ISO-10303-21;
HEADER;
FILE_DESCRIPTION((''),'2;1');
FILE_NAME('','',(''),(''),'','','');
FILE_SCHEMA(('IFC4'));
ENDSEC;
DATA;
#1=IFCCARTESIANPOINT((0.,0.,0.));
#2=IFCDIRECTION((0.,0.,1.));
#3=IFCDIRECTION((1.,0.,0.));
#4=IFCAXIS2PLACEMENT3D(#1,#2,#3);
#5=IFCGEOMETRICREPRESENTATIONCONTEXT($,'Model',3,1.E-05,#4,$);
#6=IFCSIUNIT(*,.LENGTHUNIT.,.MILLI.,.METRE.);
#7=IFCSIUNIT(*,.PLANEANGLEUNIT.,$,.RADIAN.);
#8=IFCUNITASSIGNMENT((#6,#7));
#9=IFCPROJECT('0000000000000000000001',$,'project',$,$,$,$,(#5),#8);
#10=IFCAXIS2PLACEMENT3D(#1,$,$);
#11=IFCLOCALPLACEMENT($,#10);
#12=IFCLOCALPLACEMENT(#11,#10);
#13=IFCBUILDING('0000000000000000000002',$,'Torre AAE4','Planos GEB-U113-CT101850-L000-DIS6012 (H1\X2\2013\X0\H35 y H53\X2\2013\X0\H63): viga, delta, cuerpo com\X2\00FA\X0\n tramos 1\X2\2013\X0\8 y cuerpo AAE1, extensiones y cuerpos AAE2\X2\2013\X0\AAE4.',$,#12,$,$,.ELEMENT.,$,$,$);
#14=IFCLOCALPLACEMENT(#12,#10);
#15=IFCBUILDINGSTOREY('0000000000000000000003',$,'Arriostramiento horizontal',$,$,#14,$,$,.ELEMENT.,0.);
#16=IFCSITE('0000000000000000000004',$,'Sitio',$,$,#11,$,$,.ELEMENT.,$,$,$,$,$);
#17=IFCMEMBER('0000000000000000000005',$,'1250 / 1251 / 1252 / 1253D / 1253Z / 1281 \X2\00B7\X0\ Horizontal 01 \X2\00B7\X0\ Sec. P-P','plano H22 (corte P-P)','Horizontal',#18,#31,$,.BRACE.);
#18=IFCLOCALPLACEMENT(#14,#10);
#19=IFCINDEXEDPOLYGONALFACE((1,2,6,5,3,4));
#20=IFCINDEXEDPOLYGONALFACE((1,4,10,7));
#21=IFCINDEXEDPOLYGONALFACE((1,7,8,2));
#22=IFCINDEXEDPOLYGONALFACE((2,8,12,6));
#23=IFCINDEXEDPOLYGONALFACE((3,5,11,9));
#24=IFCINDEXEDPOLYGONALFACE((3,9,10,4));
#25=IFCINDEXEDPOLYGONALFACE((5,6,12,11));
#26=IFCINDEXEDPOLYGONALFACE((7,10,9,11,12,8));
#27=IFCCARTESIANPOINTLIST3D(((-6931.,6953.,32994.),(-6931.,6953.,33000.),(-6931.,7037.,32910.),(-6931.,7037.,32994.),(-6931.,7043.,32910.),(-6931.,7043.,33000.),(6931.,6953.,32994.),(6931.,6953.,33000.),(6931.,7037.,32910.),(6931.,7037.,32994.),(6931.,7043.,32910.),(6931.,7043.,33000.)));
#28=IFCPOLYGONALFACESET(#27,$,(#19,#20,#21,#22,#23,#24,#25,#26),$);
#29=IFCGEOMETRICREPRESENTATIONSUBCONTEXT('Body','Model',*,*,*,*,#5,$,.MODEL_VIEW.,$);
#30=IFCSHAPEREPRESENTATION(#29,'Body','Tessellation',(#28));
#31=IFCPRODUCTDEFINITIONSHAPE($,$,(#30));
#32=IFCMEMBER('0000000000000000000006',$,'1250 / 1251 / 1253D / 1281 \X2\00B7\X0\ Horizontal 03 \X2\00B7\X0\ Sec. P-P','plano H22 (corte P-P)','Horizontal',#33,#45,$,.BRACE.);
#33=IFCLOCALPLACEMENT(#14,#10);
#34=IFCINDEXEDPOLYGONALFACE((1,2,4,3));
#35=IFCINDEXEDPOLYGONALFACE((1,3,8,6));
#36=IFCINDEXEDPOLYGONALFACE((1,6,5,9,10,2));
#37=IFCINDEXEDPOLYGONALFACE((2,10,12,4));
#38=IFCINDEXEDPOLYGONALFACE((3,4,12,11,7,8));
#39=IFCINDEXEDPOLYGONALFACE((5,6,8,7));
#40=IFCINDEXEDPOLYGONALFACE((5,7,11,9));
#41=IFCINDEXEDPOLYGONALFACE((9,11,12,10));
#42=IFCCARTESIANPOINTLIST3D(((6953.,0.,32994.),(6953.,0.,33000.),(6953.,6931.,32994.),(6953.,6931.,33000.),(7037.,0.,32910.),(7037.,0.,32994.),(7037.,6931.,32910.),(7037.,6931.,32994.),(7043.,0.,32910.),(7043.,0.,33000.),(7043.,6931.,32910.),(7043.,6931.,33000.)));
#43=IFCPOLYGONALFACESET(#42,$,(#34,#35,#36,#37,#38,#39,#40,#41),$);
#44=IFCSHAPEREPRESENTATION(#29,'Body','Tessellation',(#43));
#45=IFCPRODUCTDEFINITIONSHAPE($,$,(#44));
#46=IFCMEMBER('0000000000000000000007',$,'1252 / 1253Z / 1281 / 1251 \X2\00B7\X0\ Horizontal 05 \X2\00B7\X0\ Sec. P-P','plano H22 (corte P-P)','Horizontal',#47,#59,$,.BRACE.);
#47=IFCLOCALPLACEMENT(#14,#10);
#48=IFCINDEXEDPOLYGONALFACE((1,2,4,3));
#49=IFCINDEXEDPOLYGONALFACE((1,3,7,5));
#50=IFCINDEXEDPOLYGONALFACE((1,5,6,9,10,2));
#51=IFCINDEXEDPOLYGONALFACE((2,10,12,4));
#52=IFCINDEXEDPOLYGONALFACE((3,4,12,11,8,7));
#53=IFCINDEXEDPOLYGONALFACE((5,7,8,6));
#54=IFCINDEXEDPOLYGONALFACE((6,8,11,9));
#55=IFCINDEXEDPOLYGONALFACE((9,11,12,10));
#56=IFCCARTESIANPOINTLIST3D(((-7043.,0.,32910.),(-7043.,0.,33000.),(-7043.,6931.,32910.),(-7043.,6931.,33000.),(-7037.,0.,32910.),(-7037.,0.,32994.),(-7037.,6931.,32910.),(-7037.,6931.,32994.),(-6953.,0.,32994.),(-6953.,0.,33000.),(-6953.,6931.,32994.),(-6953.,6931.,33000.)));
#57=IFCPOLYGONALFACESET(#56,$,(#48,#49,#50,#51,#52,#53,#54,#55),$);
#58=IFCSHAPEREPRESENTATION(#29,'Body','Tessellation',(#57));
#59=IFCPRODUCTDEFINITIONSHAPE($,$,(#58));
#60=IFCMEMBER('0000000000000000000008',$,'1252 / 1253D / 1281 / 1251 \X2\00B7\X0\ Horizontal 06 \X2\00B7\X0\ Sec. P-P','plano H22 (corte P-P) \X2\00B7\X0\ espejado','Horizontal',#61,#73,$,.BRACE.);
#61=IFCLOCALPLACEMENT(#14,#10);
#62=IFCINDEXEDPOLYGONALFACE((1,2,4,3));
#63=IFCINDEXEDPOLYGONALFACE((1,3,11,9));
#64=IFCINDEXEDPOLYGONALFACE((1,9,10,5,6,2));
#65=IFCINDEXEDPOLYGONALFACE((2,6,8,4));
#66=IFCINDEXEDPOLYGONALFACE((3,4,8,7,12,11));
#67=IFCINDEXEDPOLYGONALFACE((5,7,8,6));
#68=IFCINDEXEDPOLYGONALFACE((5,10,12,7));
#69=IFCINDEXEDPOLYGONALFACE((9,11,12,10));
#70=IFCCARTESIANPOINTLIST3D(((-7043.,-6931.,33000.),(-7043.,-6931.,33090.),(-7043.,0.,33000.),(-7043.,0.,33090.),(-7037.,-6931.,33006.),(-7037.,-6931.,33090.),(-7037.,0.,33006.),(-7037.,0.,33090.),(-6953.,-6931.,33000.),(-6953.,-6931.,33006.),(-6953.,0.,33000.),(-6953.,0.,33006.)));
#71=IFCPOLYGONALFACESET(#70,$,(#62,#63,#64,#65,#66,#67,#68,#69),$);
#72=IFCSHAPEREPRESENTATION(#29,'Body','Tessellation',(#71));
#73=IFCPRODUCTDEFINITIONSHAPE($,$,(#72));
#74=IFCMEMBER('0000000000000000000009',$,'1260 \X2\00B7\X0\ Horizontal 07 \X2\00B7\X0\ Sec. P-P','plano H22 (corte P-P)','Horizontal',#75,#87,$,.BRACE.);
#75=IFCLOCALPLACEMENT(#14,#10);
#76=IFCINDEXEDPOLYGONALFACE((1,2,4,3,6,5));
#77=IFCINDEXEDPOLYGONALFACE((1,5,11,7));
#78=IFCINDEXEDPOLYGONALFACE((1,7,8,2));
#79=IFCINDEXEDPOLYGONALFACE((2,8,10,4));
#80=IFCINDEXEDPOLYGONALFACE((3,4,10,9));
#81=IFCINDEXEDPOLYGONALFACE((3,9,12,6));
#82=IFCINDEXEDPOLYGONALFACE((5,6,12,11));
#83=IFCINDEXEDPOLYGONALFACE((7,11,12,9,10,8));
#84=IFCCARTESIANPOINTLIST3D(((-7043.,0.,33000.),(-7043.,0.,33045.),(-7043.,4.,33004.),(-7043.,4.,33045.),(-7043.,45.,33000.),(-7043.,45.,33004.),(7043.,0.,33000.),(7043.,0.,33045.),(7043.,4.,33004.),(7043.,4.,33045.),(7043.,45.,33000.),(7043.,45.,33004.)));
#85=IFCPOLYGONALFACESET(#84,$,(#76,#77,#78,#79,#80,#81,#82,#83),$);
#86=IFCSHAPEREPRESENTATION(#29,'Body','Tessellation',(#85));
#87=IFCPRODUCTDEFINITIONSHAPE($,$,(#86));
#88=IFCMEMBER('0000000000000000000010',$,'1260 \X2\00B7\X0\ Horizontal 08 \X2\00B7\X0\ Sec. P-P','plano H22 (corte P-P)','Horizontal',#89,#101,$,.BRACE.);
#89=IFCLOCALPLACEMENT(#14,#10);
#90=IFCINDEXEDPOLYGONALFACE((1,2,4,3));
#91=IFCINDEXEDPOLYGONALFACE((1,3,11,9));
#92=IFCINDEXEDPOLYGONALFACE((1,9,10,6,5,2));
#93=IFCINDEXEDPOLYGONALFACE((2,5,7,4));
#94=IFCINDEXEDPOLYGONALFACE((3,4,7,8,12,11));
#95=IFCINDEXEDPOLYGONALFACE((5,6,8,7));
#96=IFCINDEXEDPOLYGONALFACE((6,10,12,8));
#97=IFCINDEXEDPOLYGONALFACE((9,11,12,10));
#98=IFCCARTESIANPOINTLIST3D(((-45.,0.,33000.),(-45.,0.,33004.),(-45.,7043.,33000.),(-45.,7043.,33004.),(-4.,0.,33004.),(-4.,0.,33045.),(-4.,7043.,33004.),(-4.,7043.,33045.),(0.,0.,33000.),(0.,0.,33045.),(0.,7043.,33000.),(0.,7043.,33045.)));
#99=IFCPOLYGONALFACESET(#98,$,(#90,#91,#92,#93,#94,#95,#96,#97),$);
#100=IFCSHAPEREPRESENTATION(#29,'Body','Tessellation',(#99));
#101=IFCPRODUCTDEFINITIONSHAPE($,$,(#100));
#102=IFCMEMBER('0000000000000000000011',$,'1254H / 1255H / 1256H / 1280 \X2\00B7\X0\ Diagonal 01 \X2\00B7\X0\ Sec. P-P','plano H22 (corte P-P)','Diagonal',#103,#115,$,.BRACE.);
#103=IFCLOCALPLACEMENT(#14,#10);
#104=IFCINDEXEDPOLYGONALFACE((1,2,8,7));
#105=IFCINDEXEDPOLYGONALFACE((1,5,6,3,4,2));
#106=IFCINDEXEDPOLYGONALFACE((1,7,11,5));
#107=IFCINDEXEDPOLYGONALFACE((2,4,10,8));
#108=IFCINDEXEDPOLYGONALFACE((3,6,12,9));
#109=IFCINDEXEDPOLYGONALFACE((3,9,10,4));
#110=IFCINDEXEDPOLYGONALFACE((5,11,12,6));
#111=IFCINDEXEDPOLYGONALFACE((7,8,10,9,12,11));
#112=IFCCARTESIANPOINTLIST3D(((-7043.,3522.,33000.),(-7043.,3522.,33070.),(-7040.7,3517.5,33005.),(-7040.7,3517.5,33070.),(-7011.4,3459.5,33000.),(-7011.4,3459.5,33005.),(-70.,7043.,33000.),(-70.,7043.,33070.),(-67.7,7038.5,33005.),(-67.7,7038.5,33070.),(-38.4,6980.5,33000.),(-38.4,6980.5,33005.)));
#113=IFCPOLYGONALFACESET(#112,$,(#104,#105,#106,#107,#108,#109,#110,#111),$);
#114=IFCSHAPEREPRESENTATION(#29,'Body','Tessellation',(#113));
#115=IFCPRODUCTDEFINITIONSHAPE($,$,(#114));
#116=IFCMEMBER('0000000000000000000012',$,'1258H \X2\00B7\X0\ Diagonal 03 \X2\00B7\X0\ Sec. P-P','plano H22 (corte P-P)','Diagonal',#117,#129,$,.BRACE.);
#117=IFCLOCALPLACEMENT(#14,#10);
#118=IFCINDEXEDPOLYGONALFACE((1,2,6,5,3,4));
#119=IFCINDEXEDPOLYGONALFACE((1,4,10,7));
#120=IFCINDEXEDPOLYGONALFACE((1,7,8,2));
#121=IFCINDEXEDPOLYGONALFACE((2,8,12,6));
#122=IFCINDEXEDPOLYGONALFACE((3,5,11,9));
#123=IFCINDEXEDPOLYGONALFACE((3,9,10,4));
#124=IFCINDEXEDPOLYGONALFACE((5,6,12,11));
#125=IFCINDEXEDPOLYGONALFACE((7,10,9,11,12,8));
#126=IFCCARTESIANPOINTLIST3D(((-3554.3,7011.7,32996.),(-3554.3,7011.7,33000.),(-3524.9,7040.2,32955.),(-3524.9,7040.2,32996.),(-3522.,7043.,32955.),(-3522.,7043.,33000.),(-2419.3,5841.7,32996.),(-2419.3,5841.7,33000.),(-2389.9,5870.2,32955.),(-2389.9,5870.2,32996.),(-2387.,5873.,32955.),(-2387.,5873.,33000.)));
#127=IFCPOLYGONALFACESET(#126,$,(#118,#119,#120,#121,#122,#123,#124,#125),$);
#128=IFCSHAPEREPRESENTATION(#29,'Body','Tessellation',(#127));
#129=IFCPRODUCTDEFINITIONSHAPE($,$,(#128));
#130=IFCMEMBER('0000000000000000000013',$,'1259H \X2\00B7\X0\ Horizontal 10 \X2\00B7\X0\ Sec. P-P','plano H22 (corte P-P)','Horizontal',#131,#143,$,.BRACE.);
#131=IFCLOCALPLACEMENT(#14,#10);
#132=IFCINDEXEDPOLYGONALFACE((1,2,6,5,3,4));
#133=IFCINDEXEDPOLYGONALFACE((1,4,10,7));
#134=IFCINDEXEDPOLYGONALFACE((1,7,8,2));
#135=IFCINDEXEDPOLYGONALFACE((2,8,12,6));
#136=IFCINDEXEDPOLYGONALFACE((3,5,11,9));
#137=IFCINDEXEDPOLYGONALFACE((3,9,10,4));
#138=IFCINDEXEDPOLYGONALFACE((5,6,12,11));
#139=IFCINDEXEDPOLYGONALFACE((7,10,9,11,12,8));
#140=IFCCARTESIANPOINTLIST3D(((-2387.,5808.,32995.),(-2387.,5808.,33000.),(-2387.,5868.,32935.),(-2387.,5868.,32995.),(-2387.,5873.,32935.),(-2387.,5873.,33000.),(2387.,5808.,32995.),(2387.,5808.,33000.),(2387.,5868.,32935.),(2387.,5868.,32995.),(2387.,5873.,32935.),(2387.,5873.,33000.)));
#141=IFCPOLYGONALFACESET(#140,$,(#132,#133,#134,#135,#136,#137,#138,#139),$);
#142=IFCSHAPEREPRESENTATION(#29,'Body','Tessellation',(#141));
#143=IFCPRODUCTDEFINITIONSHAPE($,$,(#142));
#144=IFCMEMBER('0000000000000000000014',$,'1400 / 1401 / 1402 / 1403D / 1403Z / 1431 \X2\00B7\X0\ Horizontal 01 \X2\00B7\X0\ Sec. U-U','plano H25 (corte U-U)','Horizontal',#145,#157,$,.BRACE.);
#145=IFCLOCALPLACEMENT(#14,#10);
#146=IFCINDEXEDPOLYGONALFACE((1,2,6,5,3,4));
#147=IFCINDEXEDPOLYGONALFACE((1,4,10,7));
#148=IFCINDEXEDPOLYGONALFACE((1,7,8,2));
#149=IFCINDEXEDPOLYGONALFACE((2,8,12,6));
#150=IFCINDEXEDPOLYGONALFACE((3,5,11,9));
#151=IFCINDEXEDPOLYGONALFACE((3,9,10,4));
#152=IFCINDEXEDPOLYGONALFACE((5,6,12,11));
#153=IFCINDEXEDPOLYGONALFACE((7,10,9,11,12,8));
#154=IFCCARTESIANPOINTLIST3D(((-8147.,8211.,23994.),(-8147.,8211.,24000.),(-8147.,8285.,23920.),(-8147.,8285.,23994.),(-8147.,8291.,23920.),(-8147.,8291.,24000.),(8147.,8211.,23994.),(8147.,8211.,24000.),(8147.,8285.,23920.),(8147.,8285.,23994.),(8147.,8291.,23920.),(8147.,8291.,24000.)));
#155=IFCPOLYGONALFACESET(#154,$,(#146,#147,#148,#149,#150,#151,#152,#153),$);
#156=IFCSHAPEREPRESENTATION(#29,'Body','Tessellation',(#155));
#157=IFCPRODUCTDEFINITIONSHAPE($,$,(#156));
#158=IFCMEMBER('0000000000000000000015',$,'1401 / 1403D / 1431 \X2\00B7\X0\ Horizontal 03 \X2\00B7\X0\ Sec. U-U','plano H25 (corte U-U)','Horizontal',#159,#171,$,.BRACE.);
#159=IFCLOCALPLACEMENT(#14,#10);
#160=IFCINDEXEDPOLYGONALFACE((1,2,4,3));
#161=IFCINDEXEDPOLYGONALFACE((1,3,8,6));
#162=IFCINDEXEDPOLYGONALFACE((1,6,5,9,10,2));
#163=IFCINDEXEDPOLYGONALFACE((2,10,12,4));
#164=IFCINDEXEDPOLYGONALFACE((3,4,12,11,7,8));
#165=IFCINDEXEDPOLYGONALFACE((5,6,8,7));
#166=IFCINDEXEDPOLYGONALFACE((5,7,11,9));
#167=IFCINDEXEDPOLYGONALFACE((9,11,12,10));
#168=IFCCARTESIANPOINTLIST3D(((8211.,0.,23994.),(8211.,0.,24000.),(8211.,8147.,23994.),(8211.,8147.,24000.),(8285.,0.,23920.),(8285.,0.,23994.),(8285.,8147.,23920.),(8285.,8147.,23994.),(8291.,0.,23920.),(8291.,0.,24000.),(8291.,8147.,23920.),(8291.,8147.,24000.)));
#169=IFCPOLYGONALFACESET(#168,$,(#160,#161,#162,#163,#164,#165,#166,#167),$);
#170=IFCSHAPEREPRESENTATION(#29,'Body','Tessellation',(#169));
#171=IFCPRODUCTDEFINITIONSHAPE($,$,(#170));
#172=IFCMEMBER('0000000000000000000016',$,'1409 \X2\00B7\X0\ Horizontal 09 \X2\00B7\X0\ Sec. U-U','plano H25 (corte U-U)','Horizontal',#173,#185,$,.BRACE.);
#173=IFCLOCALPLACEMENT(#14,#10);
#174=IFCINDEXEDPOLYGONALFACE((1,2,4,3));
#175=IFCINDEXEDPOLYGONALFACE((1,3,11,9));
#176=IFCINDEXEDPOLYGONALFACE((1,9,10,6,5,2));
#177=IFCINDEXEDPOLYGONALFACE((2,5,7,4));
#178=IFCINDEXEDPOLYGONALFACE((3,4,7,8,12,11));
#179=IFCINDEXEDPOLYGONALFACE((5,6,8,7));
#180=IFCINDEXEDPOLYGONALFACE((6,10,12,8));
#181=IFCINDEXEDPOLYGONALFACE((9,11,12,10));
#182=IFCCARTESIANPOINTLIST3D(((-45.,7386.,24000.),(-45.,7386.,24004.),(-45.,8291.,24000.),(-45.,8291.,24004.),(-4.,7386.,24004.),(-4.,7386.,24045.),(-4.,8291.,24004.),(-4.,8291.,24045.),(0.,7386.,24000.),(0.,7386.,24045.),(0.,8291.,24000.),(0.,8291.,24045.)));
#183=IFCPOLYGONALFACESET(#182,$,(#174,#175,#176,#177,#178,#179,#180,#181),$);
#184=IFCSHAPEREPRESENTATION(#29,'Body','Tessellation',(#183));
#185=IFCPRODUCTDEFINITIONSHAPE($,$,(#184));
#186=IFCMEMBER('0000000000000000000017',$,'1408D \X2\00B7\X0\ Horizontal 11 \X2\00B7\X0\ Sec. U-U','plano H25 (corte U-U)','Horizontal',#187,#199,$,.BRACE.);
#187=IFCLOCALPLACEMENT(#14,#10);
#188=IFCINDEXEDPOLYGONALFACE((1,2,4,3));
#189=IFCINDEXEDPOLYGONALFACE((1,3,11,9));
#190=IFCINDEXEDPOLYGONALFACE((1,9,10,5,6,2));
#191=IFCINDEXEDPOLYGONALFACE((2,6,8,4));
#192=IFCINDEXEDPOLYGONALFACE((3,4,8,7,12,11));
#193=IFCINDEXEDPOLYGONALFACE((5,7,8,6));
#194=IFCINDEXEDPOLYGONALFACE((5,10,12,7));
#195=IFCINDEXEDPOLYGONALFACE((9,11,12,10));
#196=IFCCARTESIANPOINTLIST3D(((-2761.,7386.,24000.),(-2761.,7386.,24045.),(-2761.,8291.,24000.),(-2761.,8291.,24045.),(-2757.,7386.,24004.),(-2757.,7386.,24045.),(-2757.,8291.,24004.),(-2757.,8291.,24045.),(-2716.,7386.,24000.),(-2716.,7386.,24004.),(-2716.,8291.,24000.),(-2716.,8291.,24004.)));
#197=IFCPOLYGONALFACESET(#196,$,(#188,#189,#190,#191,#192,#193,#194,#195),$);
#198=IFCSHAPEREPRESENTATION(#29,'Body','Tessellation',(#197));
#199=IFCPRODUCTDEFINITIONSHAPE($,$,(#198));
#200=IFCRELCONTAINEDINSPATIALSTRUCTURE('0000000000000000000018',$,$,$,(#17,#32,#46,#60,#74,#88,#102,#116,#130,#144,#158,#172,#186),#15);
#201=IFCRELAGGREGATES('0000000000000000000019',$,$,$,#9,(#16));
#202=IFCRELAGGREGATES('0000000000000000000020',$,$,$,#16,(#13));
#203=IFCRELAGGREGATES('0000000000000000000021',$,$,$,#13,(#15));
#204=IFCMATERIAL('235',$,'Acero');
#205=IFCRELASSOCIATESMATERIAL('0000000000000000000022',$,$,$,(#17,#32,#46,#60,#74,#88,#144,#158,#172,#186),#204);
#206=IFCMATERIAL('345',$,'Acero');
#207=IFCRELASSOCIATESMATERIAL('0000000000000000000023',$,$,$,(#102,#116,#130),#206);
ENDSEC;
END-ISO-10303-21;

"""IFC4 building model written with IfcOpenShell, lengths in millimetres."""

from ifc_helpers import new_model, si_unit, frame, frame_2d, origin, origin_with_axes, place, context, subcontext, project, spatial, l_section, extrude, material, element, save


model = new_model("IFC4")

# Units and contexts
model_context = context("Model", 3, precision=1e-05, world=origin_with_axes())
body_context = subcontext(model_context, "Body", "Model", "MODEL_VIEW")
ifc_project = project(units=[si_unit("LENGTHUNIT", "METRE", prefix="MILLI"), si_unit("PLANEANGLEUNIT", "RADIAN")], contexts=[model_context])

# Site, building, storey
site_placement = place(None, origin())
site = spatial("IfcSite", under=ifc_project, at=site_placement, Name="Sitio", CompositionType="ELEMENT")
building_placement = place(site_placement, origin())
building = spatial("IfcBuilding", under=site, at=building_placement, Name="Torre AAE4", Description="Planos GEB-U113-CT101850-L000-DIS6012 (H1–H35 y H53–H63): viga, delta, cuerpo común tramos 1–8 y cuerpo AAE1, extensiones y cuerpos AAE2–AAE4.", CompositionType="ELEMENT")
storey_placement = place(building_placement, origin())
storey = spatial("IfcBuildingStorey", under=building, at=storey_placement, Name="Arriostramiento horizontal", CompositionType="ELEMENT", Elevation=0.0)

# Members
ifc_material_1 = material(Name="235", Category="Acero")
member_1_placement = place(storey_placement, frame((-6931.0, 7043.0, 33000.0), z_axis=(1.0, 0.0, 0.0), x_axis=(0.0, -1.0, 0.0)))
element("IfcMember", 1, at=member_1_placement, inside=storey, material=ifc_material_1, Name="1250 / 1251 / 1252 / 1253D / 1253Z / 1281 · Horizontal 01 · Sec. P-P", Description="plano H22 (corte P-P)", ObjectType="Horizontal", PredefinedType="BRACE", context=body_context, shape_type="SweptSolid", body=[
    extrude(l_section(Depth=90.0, Width=90.0, Thickness=6.0, at=frame_2d((45.0, 45.0))), None, (0.0, 0.0, 1.0), 13862.0),
])
for number, where, z_axis, x_axis, name, description in (
    (2, (7043.0, 6931.0, 33000.0), (0.0, -1.0, 0.0), (-1.0, 0.0, 0.0), "1250 / 1251 / 1253D / 1281 · Horizontal 03 · Sec. P-P", "plano H22 (corte P-P)"),
    (3, (-7043.0, 0.0, 33000.0), (0.0, 1.0, 0.0), (1.0, 0.0, 0.0), "1252 / 1253Z / 1281 / 1251 · Horizontal 05 · Sec. P-P", "plano H22 (corte P-P)"),
    (4, (-7043.0, 0.0, 33000.0), (0.0, -1.0, 0.0), (1.0, 0.0, 0.0), "1252 / 1253D / 1281 / 1251 · Horizontal 06 · Sec. P-P", "plano H22 (corte P-P) · espejado"),
):
    element("IfcMember", number, at=place(storey_placement, frame(where, z_axis=z_axis, x_axis=x_axis)), inside=storey, material=ifc_material_1, Name=name, Description=description, ObjectType="Horizontal", PredefinedType="BRACE", context=body_context, shape_type="SweptSolid", body=[
        extrude(l_section(Depth=90.0, Width=90.0, Thickness=6.0, at=frame_2d((45.0, 45.0))), None, (0.0, 0.0, 1.0), 6931.0),
    ])
member_2_placement = place(storey_placement, frame((7043.0, 0.0, 33000.0), z_axis=(-1.0, 0.0, 0.0), x_axis=(0.0, 0.0, 1.0)))
element("IfcMember", 5, at=member_2_placement, inside=storey, material=ifc_material_1, Name="1260 · Horizontal 07 · Sec. P-P", Description="plano H22 (corte P-P)", ObjectType="Horizontal", PredefinedType="BRACE", context=body_context, shape_type="SweptSolid", body=[
    extrude(l_section(Depth=45.0, Width=45.0, Thickness=4.0, at=frame_2d((22.5, 22.5))), None, (0.0, 0.0, 1.0), 14086.0),
])
member_3_placement = place(storey_placement, frame((0.0, 7043.0, 33000.0), z_axis=(0.0, -1.0, 0.0), x_axis=(0.0, 0.0, 1.0)))
element("IfcMember", 6, at=member_3_placement, inside=storey, material=ifc_material_1, Name="1260 · Horizontal 08 · Sec. P-P", Description="plano H22 (corte P-P)", ObjectType="Horizontal", PredefinedType="BRACE", context=body_context, shape_type="SweptSolid", body=[
    extrude(l_section(Depth=45.0, Width=45.0, Thickness=4.0, at=frame_2d((22.5, 22.5))), None, (0.0, 0.0, 1.0), 7043.0),
])
ifc_material_2 = material(Name="345", Category="Acero")
member_4_placement = place(storey_placement, frame((-70.0, 7043.0, 33000.0), z_axis=(-0.892654, -0.450743, 0.0), x_axis=(0.450743, -0.892654, 0.0)))
element("IfcMember", 7, at=member_4_placement, inside=storey, material=ifc_material_2, Name="1254H / 1255H / 1256H / 1280 · Diagonal 01 · Sec. P-P", Description="plano H22 (corte P-P)", ObjectType="Diagonal", PredefinedType="BRACE", context=body_context, shape_type="SweptSolid", body=[
    extrude(l_section(Depth=70.0, Width=70.0, Thickness=5.0, at=frame_2d((35.0, 35.0))), None, (0.0, 0.0, 1.0), 7811.5),
])
member_5_placement = place(storey_placement, frame((-3522.0, 7043.0, 33000.0), z_axis=(0.69629, -0.717761, 0.0), x_axis=(-0.717761, -0.69629, 0.0)))
element("IfcMember", 8, at=member_5_placement, inside=storey, material=ifc_material_2, Name="1258H · Diagonal 03 · Sec. P-P", Description="plano H22 (corte P-P)", ObjectType="Diagonal", PredefinedType="BRACE", context=body_context, shape_type="SweptSolid", body=[
    extrude(l_section(Depth=45.0, Width=45.0, Thickness=4.0, at=frame_2d((22.5, 22.5))), None, (0.0, 0.0, 1.0), 1630.1),
])
member_6_placement = place(storey_placement, frame((-2387.0, 5873.0, 33000.0), z_axis=(1.0, 0.0, 0.0), x_axis=(0.0, -1.0, 0.0)))
element("IfcMember", 9, at=member_6_placement, inside=storey, material=ifc_material_2, Name="1259H · Horizontal 10 · Sec. P-P", Description="plano H22 (corte P-P)", ObjectType="Horizontal", PredefinedType="BRACE", context=body_context, shape_type="SweptSolid", body=[
    extrude(l_section(Depth=65.0, Width=65.0, Thickness=5.0, at=frame_2d((32.5, 32.5))), None, (0.0, 0.0, 1.0), 4774.0),
])
member_7_placement = place(storey_placement, frame((-8147.0, 8291.0, 24000.0), z_axis=(1.0, 0.0, 0.0), x_axis=(0.0, -1.0, 0.0)))
element("IfcMember", 10, at=member_7_placement, inside=storey, material=ifc_material_1, Name="1400 / 1401 / 1402 / 1403D / 1403Z / 1431 · Horizontal 01 · Sec. U-U", Description="plano H25 (corte U-U)", ObjectType="Horizontal", PredefinedType="BRACE", context=body_context, shape_type="SweptSolid", body=[
    extrude(l_section(Depth=80.0, Width=80.0, Thickness=6.0, at=frame_2d((40.0, 40.0))), None, (0.0, 0.0, 1.0), 16294.0),
])
member_8_placement = place(storey_placement, frame((8291.0, 8147.0, 24000.0), z_axis=(0.0, -1.0, 0.0), x_axis=(-1.0, 0.0, 0.0)))
element("IfcMember", 11, at=member_8_placement, inside=storey, material=ifc_material_1, Name="1401 / 1403D / 1431 · Horizontal 03 · Sec. U-U", Description="plano H25 (corte U-U)", ObjectType="Horizontal", PredefinedType="BRACE", context=body_context, shape_type="SweptSolid", body=[
    extrude(l_section(Depth=80.0, Width=80.0, Thickness=6.0, at=frame_2d((40.0, 40.0))), None, (0.0, 0.0, 1.0), 8147.0),
])
for number, where, z_axis, x_axis, name in (
    (12, (0.0, 8291.0, 24000.0), (0.0, -1.0, 0.0), (0.0, 0.0, 1.0), "1409 · Horizontal 09 · Sec. U-U"),
    (13, (-2761.0, 8291.0, 24000.0), (0.0, -1.0, 0.0), (1.0, 0.0, 0.0), "1408D · Horizontal 11 · Sec. U-U"),
):
    element("IfcMember", number, at=place(storey_placement, frame(where, z_axis=z_axis, x_axis=x_axis)), inside=storey, material=ifc_material_1, Name=name, Description="plano H25 (corte U-U)", ObjectType="Horizontal", PredefinedType="BRACE", context=body_context, shape_type="SweptSolid", body=[
        extrude(l_section(Depth=45.0, Width=45.0, Thickness=4.0, at=frame_2d((22.5, 22.5))), None, (0.0, 0.0, 1.0), 905.0),
    ])

save(model, "model.ifc")
